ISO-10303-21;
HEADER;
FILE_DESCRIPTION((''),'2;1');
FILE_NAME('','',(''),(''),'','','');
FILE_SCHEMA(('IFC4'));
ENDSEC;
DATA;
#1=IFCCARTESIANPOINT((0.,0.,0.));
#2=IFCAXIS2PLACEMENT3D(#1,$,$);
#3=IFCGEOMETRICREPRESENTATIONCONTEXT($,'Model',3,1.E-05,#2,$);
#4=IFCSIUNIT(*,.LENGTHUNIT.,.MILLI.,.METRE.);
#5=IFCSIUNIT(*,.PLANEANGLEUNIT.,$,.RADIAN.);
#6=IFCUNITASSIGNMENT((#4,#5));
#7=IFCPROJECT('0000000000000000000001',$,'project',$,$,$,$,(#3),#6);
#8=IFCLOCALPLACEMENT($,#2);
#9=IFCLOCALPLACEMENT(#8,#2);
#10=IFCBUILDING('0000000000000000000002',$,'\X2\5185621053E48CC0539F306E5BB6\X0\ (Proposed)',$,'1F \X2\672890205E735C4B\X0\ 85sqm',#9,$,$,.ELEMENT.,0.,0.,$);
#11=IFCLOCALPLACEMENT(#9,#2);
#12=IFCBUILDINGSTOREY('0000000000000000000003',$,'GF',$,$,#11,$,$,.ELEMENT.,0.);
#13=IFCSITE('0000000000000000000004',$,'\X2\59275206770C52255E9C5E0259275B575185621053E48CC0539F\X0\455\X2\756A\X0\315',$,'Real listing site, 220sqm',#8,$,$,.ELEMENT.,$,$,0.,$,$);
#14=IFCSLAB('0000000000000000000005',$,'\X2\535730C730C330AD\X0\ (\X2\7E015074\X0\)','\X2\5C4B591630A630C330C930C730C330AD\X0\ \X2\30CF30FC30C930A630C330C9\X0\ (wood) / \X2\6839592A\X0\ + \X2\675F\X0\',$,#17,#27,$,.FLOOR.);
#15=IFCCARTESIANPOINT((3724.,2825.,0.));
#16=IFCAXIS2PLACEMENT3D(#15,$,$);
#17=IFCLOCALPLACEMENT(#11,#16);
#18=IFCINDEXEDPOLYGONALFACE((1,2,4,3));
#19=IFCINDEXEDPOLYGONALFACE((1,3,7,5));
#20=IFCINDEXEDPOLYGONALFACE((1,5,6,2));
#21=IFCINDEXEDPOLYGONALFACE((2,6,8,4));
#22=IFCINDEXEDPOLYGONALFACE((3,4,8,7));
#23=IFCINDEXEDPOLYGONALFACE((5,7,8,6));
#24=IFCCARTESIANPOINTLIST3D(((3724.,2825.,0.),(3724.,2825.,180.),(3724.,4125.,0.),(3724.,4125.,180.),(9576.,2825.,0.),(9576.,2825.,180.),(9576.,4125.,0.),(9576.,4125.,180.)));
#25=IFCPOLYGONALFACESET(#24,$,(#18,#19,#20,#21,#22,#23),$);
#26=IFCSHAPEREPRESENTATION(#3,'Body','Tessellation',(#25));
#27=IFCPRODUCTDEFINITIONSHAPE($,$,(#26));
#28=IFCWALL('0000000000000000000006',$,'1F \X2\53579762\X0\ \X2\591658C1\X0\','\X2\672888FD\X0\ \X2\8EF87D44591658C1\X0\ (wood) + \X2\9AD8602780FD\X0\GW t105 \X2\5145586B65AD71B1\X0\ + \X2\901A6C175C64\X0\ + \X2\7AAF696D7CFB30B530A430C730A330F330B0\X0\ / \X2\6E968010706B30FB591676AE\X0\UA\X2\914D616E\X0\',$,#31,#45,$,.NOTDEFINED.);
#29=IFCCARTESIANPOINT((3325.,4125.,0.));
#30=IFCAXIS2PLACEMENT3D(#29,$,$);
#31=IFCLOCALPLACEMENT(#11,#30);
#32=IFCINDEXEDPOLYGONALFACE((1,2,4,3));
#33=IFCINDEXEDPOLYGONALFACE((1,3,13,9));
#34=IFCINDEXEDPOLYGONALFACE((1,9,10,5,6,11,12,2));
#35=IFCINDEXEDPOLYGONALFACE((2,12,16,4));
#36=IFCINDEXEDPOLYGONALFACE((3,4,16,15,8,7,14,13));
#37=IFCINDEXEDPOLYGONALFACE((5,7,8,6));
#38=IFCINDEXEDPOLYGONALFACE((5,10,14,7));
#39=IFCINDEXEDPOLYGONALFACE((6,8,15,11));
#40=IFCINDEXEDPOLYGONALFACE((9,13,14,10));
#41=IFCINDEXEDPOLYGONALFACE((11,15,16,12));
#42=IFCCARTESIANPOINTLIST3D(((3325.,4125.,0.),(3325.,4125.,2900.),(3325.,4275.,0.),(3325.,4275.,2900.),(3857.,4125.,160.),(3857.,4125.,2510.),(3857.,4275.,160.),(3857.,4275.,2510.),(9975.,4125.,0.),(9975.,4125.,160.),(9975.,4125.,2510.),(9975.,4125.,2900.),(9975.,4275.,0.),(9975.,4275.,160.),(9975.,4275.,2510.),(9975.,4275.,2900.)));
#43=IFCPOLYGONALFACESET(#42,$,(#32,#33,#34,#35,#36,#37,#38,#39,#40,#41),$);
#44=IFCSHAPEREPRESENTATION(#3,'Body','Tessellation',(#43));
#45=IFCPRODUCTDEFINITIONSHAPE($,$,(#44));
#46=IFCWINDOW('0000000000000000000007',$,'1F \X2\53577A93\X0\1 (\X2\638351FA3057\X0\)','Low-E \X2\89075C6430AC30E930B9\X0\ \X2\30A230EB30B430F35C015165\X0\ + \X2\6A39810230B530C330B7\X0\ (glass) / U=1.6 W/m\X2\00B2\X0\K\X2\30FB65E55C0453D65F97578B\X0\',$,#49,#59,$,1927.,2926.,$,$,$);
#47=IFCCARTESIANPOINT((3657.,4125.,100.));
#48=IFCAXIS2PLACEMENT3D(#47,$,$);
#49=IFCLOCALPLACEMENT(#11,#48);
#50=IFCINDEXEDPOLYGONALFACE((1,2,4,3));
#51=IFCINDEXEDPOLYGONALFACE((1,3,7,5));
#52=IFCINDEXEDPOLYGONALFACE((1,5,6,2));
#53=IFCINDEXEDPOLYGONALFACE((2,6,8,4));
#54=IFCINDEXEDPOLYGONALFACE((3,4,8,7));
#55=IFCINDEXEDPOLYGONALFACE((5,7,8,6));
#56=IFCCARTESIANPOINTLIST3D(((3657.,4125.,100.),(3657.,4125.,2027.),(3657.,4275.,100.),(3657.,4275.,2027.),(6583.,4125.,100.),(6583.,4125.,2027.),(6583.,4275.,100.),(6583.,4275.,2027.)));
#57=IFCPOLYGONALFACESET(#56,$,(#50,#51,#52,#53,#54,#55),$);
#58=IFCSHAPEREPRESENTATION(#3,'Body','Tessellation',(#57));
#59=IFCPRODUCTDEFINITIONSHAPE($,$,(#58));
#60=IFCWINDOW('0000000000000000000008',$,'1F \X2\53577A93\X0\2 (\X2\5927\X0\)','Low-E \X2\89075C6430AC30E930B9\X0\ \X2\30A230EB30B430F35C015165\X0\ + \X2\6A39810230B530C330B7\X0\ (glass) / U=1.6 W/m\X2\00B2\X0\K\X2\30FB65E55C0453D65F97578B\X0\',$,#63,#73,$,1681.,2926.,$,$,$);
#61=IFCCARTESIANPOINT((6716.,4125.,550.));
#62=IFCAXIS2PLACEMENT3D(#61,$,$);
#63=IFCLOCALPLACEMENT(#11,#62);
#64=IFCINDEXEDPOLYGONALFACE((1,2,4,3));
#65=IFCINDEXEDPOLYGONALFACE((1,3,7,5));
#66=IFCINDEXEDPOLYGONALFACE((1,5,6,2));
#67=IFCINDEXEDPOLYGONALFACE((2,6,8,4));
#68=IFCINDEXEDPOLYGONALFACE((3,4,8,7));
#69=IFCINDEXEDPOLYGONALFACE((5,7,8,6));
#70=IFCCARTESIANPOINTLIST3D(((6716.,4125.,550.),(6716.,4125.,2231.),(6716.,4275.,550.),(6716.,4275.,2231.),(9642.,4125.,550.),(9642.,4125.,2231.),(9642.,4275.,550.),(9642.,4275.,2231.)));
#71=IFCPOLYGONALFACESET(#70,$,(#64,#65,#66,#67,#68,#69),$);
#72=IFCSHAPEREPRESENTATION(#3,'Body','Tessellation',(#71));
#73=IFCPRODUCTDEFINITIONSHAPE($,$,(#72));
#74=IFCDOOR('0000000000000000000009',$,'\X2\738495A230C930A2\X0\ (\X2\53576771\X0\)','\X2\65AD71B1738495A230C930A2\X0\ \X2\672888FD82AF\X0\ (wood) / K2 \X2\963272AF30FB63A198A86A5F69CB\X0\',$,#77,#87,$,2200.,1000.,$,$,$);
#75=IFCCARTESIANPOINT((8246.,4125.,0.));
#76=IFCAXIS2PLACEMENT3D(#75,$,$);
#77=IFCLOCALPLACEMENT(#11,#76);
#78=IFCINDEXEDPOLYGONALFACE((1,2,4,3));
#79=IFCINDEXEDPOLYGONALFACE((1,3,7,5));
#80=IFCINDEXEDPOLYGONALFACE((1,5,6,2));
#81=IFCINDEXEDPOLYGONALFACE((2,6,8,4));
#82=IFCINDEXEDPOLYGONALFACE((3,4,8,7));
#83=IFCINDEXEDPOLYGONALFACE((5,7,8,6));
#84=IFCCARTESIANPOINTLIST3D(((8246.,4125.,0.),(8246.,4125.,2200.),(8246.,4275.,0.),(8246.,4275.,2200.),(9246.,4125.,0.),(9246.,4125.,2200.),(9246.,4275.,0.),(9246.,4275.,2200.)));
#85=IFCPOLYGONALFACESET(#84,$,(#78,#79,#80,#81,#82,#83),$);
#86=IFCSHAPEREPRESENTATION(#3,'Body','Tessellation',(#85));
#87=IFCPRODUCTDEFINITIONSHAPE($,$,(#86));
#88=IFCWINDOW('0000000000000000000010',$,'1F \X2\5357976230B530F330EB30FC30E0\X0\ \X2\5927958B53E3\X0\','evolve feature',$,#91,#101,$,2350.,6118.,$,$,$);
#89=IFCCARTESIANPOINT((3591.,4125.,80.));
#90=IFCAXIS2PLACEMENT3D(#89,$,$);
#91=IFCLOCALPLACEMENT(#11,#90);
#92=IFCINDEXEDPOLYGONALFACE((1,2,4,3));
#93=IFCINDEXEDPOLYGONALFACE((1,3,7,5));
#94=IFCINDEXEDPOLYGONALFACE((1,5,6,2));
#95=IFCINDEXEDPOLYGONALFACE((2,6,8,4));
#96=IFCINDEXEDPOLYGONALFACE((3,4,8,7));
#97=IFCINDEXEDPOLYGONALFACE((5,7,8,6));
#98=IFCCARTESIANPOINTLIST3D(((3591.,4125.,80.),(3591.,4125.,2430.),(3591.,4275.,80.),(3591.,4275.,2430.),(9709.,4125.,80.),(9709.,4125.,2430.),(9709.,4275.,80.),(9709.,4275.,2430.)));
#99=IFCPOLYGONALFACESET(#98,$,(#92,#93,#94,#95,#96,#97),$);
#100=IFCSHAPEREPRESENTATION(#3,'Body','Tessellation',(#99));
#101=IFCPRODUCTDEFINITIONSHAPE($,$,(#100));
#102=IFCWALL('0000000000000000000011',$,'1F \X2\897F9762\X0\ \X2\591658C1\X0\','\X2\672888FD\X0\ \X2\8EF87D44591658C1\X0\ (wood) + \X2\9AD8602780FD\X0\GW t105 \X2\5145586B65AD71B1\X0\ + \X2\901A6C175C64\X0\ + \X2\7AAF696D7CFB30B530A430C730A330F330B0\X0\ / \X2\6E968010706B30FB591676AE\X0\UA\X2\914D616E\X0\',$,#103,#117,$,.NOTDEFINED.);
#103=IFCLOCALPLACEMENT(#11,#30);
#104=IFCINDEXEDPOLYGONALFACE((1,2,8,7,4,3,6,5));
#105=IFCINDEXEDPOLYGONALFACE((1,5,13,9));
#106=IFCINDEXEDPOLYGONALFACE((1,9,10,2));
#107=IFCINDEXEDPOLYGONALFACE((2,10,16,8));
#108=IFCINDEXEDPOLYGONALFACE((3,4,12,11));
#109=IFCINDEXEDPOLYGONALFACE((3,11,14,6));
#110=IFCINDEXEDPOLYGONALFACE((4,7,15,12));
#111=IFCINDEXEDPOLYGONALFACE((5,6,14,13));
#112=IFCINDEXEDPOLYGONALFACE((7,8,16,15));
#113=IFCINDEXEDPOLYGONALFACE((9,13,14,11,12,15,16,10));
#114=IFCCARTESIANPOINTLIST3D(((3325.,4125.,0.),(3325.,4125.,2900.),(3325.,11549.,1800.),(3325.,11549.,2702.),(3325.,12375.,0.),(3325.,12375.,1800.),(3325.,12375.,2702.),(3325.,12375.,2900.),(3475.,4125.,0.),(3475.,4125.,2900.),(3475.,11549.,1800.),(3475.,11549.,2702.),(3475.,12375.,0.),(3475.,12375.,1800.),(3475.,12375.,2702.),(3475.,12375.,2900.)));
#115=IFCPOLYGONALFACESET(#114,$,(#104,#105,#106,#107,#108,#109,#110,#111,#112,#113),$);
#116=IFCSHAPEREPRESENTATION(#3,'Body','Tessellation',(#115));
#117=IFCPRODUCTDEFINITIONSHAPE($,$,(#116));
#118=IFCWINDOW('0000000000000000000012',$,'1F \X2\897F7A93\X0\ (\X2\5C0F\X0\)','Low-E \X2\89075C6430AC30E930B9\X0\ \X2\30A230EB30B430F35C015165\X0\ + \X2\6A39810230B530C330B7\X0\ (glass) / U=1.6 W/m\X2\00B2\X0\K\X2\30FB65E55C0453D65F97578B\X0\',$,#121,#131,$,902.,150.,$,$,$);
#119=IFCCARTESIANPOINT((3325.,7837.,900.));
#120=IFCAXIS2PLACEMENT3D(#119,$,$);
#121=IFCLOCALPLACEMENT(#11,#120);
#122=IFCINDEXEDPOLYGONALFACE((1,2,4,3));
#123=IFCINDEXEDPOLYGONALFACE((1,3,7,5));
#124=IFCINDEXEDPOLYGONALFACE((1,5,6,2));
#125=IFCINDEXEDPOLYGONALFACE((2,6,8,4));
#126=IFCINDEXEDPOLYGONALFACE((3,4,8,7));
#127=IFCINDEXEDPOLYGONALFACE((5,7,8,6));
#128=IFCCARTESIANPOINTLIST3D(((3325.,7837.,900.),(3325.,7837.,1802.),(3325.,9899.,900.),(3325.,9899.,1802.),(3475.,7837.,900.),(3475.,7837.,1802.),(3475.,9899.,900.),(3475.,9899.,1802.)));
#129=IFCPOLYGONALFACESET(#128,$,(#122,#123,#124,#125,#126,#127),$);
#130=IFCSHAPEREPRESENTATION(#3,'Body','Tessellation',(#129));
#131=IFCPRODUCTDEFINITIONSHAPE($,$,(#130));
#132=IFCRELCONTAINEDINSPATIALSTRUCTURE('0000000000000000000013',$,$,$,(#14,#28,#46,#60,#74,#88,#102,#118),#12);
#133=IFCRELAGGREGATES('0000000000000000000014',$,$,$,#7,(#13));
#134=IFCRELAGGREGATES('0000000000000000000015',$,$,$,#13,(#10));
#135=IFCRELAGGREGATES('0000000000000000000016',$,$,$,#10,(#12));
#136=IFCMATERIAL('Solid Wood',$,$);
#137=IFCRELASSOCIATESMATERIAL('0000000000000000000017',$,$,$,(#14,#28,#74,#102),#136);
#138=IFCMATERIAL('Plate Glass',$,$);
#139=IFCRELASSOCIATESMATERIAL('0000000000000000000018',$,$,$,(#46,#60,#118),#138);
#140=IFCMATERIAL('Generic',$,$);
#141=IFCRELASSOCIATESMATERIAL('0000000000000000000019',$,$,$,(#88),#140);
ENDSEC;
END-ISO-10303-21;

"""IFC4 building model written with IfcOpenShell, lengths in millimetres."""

from ifc_helpers import new_model, si_unit, frame, frame_2d, origin, place, context, project, spatial, rectangle, extrude, material, element, fill, save


model = new_model("IFC4")

# Units and contexts
model_context = context("Model", 3, precision=1e-05, world=origin())
ifc_project = project(units=[si_unit("LENGTHUNIT", "METRE", prefix="MILLI"), si_unit("PLANEANGLEUNIT", "RADIAN")], contexts=[model_context])

# Site, building, storey
site_placement = place(None, origin())
site = spatial("IfcSite", under=ifc_project, at=site_placement, Name="大分県別府市大字内成古賀原455番315", ObjectType="Real listing site, 220sqm", CompositionType="ELEMENT", RefElevation=0.0)
building_placement = place(site_placement, origin())
building = spatial("IfcBuilding", under=site, at=building_placement, Name="内成古賀原の家 (Proposed)", ObjectType="1F 木造平屋 85sqm", CompositionType="ELEMENT", ElevationOfRefHeight=0.0, ElevationOfTerrain=0.0)
storey_placement = place(building_placement, origin())
storey = spatial("IfcBuildingStorey", under=building, at=storey_placement, Name="GF", CompositionType="ELEMENT", Elevation=0.0)

# Slab
ifc_material_1 = material(Name="Solid Wood")
slab_1_placement = place(storey_placement, frame((3724.0, 2825.0, 0.0)))
element("IfcSlab", 1, at=slab_1_placement, inside=storey, material=ifc_material_1, Name="南デッキ (縁側)", Description="屋外ウッドデッキ ハードウッド (wood) / 根太 + 束", PredefinedType="FLOOR", context=model_context, shape_type="SweptSolid", body=[
    extrude(rectangle(XDim=5852.0, YDim=1300.0, at=frame_2d((2926.0, 650.0))), frame((3724.0, 2825.0, 0.0)), (0.0, 0.0, 1.0), 180.0),
])
ifc_material_2 = material(Name="Generic")

# Wall, openings, windows, door
wall_1_placement = place(storey_placement, frame((3325.0, 4125.0, 0.0)))
wall_1 = element("IfcWall", 2, at=wall_1_placement, inside=storey, material=ifc_material_1, Name="1F 南面 外壁", Description="木製 軸組外壁 (wood) + 高性能GW t105 充填断熱 + 通気層 + 窯業系サイディング / 準耐火・外皮UA配慮", PredefinedType="NOTDEFINED", context=model_context, shape_type="SweptSolid", body=[
    extrude(rectangle(XDim=6650.0, YDim=150.0, at=frame_2d((3325.0, 75.0))), frame((3325.0, 4125.0, 0.0)), (0.0, 0.0, 1.0), 2900.0),
])
opening_1_placement = place(storey_placement, frame((3657.0, 4125.0, 100.0)))
opening_1 = element("IfcOpeningElement", 3, at=opening_1_placement, cuts=wall_1, PredefinedType="NOTDEFINED", context=model_context, shape_type="SweptSolid", body=[
    extrude(rectangle(XDim=2926.0, YDim=150.0, at=frame_2d((1463.0, 75.0))), frame((3657.0, 4125.0, 100.0)), (0.0, 0.0, 1.0), 1927.0),
])
opening_2_placement = place(storey_placement, frame((6716.0, 4125.0, 550.0)))
opening_2 = element("IfcOpeningElement", 4, at=opening_2_placement, cuts=wall_1, PredefinedType="NOTDEFINED", context=model_context, shape_type="SweptSolid", body=[
    extrude(rectangle(XDim=2926.0, YDim=150.0, at=frame_2d((1463.0, 75.0))), frame((6716.0, 4125.0, 550.0)), (0.0, 0.0, 1.0), 1681.0),
])
opening_3_placement = place(storey_placement, frame((8246.0, 4125.0, 0.0)))
opening_3 = element("IfcOpeningElement", 5, at=opening_3_placement, cuts=wall_1, PredefinedType="NOTDEFINED", context=model_context, shape_type="SweptSolid", body=[
    extrude(rectangle(XDim=1000.0, YDim=150.0, at=frame_2d((500.0, 75.0))), frame((8246.0, 4125.0, 0.0)), (0.0, 0.0, 1.0), 2200.0),
])
opening_4_placement = place(storey_placement, frame((3591.0, 4125.0, 80.0)))
opening_4 = element("IfcOpeningElement", 6, at=opening_4_placement, cuts=wall_1, PredefinedType="NOTDEFINED", context=model_context, shape_type="SweptSolid", body=[
    extrude(rectangle(XDim=6118.0, YDim=150.0, at=frame_2d((3059.0, 75.0))), frame((3591.0, 4125.0, 80.0)), (0.0, 0.0, 1.0), 2350.0),
])
ifc_material_3 = material(Name="Plate Glass")
window_1_placement = place(storey_placement, frame((3657.0, 4125.0, 100.0)))
window_1 = element("IfcWindow", 7, at=window_1_placement, inside=storey, material=ifc_material_3, Name="1F 南窓1 (掃出し)", Description="Low-E 複層ガラス アルゴン封入 + 樹脂サッシ (glass) / U=1.6 W/m²K・日射取得型", OverallHeight=1927.0, OverallWidth=2926.0, context=model_context, shape_type="SweptSolid", body=[
    extrude(rectangle(XDim=2926.0, YDim=150.0, at=frame_2d((1463.0, 75.0))), frame((3657.0, 4125.0, 100.0)), (0.0, 0.0, 1.0), 1927.0),
])
fill(opening_1, window_1)
window_2_placement = place(storey_placement, frame((6716.0, 4125.0, 550.0)))
window_2 = element("IfcWindow", 8, at=window_2_placement, inside=storey, material=ifc_material_3, Name="1F 南窓2 (大)", Description="Low-E 複層ガラス アルゴン封入 + 樹脂サッシ (glass) / U=1.6 W/m²K・日射取得型", OverallHeight=1681.0, OverallWidth=2926.0, context=model_context, shape_type="SweptSolid", body=[
    extrude(rectangle(XDim=2926.0, YDim=150.0, at=frame_2d((1463.0, 75.0))), frame((6716.0, 4125.0, 550.0)), (0.0, 0.0, 1.0), 1681.0),
])
fill(opening_2, window_2)
door_placement = place(storey_placement, frame((8246.0, 4125.0, 0.0)))
door = element("IfcDoor", 9, at=door_placement, inside=storey, material=ifc_material_1, Name="玄関ドア (南東)", Description="断熱玄関ドア 木製芯 (wood) / K2 防犯・採風機構", OverallHeight=2200.0, OverallWidth=1000.0, context=model_context, shape_type="SweptSolid", body=[
    extrude(rectangle(XDim=1000.0, YDim=150.0, at=frame_2d((500.0, 75.0))), frame((8246.0, 4125.0, 0.0)), (0.0, 0.0, 1.0), 2200.0),
])
fill(opening_3, door)
window_3_placement = place(storey_placement, frame((3591.0, 4125.0, 80.0)))
window_3 = element("IfcWindow", 10, at=window_3_placement, inside=storey, material=ifc_material_2, Name="1F 南面サンルーム 大開口", Description="evolve feature", OverallHeight=2350.0, OverallWidth=6118.0, context=model_context, shape_type="SweptSolid", body=[
    extrude(rectangle(XDim=6118.0, YDim=150.0, at=frame_2d((3059.0, 75.0))), frame((3591.0, 4125.0, 80.0)), (0.0, 0.0, 1.0), 2350.0),
])
fill(opening_4, window_3)

# Wall, opening, window
wall_2_placement = place(storey_placement, frame((3325.0, 4125.0, 0.0)))
wall_2 = element("IfcWall", 11, at=wall_2_placement, inside=storey, material=ifc_material_1, Name="1F 西面 外壁", Description="木製 軸組外壁 (wood) + 高性能GW t105 充填断熱 + 通気層 + 窯業系サイディング / 準耐火・外皮UA配慮", PredefinedType="NOTDEFINED", context=model_context, shape_type="SweptSolid", body=[
    extrude(rectangle(XDim=150.0, YDim=8250.0, at=frame_2d((75.0, 4125.0))), frame((3325.0, 4125.0, 0.0)), (0.0, 0.0, 1.0), 2900.0),
])
opening_5_placement = place(storey_placement, frame((3325.0, 7837.0, 900.0)))
opening_5 = element("IfcOpeningElement", 12, at=opening_5_placement, cuts=wall_2, PredefinedType="NOTDEFINED", context=model_context, shape_type="SweptSolid", body=[
    extrude(rectangle(XDim=150.0, YDim=2062.0, at=frame_2d((75.0, 1031.0))), frame((3325.0, 7837.0, 900.0)), (0.0, 0.0, 1.0), 902.0),
])
window_4_placement = place(storey_placement, frame((3325.0, 7837.0, 900.0)))
window_4 = element("IfcWindow", 13, at=window_4_placement, inside=storey, material=ifc_material_3, Name="1F 西窓 (小)", Description="Low-E 複層ガラス アルゴン封入 + 樹脂サッシ (glass) / U=1.6 W/m²K・日射取得型", OverallHeight=902.0, OverallWidth=150.0, context=model_context, shape_type="SweptSolid", body=[
    extrude(rectangle(XDim=150.0, YDim=2062.0, at=frame_2d((75.0, 1031.0))), frame((3325.0, 7837.0, 900.0)), (0.0, 0.0, 1.0), 902.0),
])
fill(opening_5, window_4)

save(model, "model.ifc")
